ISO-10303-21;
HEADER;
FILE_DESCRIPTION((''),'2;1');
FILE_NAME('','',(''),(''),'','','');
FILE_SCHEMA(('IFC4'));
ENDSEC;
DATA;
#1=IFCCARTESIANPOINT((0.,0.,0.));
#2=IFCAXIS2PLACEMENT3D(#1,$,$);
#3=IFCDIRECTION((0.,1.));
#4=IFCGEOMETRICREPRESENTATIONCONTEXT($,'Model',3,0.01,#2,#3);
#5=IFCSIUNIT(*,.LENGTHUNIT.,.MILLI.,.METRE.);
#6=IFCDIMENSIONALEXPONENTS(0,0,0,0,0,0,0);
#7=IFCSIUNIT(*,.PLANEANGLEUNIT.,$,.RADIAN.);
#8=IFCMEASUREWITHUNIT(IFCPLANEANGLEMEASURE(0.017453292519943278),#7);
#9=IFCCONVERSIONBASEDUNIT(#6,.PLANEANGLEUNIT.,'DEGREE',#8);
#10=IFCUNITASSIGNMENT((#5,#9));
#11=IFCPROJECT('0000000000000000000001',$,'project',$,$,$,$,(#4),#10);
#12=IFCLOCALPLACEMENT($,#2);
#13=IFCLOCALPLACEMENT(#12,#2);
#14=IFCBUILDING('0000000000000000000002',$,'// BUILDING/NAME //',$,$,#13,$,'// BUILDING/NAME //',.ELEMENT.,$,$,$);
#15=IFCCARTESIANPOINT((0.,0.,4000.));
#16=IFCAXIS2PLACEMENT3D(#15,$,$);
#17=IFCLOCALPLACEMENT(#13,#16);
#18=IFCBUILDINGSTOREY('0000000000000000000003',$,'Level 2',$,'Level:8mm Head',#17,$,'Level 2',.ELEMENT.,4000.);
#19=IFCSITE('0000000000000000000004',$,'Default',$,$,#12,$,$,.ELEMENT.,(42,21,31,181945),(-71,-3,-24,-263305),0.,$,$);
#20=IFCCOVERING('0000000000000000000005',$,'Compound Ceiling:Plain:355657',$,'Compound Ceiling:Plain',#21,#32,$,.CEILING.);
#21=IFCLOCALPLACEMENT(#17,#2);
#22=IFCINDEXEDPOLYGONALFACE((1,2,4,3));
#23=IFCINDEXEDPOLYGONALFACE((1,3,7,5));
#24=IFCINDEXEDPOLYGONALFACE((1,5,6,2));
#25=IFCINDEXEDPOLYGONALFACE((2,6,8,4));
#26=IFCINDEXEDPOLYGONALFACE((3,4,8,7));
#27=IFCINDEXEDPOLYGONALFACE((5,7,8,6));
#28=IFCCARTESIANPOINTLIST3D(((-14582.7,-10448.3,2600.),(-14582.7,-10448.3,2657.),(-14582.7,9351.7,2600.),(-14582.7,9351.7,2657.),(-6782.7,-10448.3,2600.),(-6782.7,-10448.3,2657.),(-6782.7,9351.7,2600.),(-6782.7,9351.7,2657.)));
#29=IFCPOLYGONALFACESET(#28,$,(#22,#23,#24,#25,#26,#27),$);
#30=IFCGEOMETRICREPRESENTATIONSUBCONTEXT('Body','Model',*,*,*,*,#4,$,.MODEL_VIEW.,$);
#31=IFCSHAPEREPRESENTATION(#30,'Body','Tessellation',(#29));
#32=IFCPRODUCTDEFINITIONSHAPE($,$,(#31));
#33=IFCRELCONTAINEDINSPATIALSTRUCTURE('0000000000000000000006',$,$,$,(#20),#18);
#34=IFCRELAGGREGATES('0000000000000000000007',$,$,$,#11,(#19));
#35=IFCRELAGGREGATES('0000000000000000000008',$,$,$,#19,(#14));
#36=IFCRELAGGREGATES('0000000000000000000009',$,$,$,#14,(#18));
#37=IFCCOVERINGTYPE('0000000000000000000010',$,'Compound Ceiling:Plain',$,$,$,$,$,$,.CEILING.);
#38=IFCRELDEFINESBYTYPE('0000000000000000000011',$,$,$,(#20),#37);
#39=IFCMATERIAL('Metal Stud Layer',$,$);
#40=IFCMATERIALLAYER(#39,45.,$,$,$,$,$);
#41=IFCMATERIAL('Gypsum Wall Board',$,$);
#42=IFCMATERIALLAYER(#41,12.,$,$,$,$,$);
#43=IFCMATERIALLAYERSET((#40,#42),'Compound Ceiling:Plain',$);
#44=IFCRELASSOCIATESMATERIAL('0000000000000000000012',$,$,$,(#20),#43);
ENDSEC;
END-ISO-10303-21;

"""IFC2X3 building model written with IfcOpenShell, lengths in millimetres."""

from ifc_helpers import new_model, entity, si_unit, converted_unit, direction, frame, frame_2d, origin, place, context, subcontext, project, spatial, rectangle, extrude, material, layer, layer_set, layer_usage, type_object, element, save


model = new_model("IFC2X3")

# Units and contexts
model_context = context("Model", 3, precision=0.01, world=origin(), true_north=direction((0.0, 1.0)))
body_context = subcontext(model_context, "Body", "Model", "MODEL_VIEW")
ifc_project = project(units=[si_unit("LENGTHUNIT", "METRE", prefix="MILLI"), converted_unit("PLANEANGLEUNIT", "DEGREE", entity("IfcPlaneAngleMeasure", 0.017453292519943278), si_unit("PLANEANGLEUNIT", "RADIAN"), dimensions=[0, 0, 0, 0, 0, 0, 0])], contexts=[model_context])

# Site, building, storey
site_placement = place(None, origin())
site = spatial("IfcSite", under=ifc_project, at=site_placement, Name="Default", CompositionType="ELEMENT", RefLatitude=(42, 21, 31, 181945), RefLongitude=(-71, -3, -24, -263305), RefElevation=0.0)
building_placement = place(site_placement, origin())
building = spatial("IfcBuilding", under=site, at=building_placement, Name="// BUILDING/NAME //", LongName="// BUILDING/NAME //", CompositionType="ELEMENT")
storey_placement = place(building_placement, frame((0.0, 0.0, 4000.0)))
storey = spatial("IfcBuildingStorey", under=building, at=storey_placement, Name="Level 2", ObjectType="Level:8mm Head", LongName="Level 2", CompositionType="ELEMENT", Elevation=4000.0)

# Covering
ifc_material_1 = material(Name="Metal Stud Layer")
ifc_layer_1 = layer(ifc_material_1, 45.0)
ifc_material_2 = material(Name="Gypsum Wall Board")
ifc_layer_2 = layer(ifc_material_2, 12.0)
ifc_layer_set_1 = layer_set([ifc_layer_1, ifc_layer_2], Name="Compound Ceiling:Plain")
ifc_layer_usage_1 = layer_usage(ifc_layer_set_1, "AXIS3", "NEGATIVE", 57.0)
covering_type = type_object("IfcCoveringType", Name="Compound Ceiling:Plain", PredefinedType="CEILING")
covering_placement = place(storey_placement, origin())
element("IfcCovering", 1, at=covering_placement, inside=storey, type_object=covering_type, material=ifc_layer_usage_1, Name="Compound Ceiling:Plain:355657", ObjectType="Compound Ceiling:Plain", PredefinedType="CEILING", context=body_context, shape_type="SweptSolid", body=[
    extrude(rectangle(XDim=7800.0, YDim=19800.0, at=frame_2d((0.0, 0.0), x_axis=(1.0, 0.0))), frame((-10682.7, -548.3, 2600.0), z_axis=(0.0, 0.0, 1.0), x_axis=(-1.0, 0.0, 0.0)), (0.0, 0.0, 1.0), 57.0),
])

save(model, "model.ifc")
